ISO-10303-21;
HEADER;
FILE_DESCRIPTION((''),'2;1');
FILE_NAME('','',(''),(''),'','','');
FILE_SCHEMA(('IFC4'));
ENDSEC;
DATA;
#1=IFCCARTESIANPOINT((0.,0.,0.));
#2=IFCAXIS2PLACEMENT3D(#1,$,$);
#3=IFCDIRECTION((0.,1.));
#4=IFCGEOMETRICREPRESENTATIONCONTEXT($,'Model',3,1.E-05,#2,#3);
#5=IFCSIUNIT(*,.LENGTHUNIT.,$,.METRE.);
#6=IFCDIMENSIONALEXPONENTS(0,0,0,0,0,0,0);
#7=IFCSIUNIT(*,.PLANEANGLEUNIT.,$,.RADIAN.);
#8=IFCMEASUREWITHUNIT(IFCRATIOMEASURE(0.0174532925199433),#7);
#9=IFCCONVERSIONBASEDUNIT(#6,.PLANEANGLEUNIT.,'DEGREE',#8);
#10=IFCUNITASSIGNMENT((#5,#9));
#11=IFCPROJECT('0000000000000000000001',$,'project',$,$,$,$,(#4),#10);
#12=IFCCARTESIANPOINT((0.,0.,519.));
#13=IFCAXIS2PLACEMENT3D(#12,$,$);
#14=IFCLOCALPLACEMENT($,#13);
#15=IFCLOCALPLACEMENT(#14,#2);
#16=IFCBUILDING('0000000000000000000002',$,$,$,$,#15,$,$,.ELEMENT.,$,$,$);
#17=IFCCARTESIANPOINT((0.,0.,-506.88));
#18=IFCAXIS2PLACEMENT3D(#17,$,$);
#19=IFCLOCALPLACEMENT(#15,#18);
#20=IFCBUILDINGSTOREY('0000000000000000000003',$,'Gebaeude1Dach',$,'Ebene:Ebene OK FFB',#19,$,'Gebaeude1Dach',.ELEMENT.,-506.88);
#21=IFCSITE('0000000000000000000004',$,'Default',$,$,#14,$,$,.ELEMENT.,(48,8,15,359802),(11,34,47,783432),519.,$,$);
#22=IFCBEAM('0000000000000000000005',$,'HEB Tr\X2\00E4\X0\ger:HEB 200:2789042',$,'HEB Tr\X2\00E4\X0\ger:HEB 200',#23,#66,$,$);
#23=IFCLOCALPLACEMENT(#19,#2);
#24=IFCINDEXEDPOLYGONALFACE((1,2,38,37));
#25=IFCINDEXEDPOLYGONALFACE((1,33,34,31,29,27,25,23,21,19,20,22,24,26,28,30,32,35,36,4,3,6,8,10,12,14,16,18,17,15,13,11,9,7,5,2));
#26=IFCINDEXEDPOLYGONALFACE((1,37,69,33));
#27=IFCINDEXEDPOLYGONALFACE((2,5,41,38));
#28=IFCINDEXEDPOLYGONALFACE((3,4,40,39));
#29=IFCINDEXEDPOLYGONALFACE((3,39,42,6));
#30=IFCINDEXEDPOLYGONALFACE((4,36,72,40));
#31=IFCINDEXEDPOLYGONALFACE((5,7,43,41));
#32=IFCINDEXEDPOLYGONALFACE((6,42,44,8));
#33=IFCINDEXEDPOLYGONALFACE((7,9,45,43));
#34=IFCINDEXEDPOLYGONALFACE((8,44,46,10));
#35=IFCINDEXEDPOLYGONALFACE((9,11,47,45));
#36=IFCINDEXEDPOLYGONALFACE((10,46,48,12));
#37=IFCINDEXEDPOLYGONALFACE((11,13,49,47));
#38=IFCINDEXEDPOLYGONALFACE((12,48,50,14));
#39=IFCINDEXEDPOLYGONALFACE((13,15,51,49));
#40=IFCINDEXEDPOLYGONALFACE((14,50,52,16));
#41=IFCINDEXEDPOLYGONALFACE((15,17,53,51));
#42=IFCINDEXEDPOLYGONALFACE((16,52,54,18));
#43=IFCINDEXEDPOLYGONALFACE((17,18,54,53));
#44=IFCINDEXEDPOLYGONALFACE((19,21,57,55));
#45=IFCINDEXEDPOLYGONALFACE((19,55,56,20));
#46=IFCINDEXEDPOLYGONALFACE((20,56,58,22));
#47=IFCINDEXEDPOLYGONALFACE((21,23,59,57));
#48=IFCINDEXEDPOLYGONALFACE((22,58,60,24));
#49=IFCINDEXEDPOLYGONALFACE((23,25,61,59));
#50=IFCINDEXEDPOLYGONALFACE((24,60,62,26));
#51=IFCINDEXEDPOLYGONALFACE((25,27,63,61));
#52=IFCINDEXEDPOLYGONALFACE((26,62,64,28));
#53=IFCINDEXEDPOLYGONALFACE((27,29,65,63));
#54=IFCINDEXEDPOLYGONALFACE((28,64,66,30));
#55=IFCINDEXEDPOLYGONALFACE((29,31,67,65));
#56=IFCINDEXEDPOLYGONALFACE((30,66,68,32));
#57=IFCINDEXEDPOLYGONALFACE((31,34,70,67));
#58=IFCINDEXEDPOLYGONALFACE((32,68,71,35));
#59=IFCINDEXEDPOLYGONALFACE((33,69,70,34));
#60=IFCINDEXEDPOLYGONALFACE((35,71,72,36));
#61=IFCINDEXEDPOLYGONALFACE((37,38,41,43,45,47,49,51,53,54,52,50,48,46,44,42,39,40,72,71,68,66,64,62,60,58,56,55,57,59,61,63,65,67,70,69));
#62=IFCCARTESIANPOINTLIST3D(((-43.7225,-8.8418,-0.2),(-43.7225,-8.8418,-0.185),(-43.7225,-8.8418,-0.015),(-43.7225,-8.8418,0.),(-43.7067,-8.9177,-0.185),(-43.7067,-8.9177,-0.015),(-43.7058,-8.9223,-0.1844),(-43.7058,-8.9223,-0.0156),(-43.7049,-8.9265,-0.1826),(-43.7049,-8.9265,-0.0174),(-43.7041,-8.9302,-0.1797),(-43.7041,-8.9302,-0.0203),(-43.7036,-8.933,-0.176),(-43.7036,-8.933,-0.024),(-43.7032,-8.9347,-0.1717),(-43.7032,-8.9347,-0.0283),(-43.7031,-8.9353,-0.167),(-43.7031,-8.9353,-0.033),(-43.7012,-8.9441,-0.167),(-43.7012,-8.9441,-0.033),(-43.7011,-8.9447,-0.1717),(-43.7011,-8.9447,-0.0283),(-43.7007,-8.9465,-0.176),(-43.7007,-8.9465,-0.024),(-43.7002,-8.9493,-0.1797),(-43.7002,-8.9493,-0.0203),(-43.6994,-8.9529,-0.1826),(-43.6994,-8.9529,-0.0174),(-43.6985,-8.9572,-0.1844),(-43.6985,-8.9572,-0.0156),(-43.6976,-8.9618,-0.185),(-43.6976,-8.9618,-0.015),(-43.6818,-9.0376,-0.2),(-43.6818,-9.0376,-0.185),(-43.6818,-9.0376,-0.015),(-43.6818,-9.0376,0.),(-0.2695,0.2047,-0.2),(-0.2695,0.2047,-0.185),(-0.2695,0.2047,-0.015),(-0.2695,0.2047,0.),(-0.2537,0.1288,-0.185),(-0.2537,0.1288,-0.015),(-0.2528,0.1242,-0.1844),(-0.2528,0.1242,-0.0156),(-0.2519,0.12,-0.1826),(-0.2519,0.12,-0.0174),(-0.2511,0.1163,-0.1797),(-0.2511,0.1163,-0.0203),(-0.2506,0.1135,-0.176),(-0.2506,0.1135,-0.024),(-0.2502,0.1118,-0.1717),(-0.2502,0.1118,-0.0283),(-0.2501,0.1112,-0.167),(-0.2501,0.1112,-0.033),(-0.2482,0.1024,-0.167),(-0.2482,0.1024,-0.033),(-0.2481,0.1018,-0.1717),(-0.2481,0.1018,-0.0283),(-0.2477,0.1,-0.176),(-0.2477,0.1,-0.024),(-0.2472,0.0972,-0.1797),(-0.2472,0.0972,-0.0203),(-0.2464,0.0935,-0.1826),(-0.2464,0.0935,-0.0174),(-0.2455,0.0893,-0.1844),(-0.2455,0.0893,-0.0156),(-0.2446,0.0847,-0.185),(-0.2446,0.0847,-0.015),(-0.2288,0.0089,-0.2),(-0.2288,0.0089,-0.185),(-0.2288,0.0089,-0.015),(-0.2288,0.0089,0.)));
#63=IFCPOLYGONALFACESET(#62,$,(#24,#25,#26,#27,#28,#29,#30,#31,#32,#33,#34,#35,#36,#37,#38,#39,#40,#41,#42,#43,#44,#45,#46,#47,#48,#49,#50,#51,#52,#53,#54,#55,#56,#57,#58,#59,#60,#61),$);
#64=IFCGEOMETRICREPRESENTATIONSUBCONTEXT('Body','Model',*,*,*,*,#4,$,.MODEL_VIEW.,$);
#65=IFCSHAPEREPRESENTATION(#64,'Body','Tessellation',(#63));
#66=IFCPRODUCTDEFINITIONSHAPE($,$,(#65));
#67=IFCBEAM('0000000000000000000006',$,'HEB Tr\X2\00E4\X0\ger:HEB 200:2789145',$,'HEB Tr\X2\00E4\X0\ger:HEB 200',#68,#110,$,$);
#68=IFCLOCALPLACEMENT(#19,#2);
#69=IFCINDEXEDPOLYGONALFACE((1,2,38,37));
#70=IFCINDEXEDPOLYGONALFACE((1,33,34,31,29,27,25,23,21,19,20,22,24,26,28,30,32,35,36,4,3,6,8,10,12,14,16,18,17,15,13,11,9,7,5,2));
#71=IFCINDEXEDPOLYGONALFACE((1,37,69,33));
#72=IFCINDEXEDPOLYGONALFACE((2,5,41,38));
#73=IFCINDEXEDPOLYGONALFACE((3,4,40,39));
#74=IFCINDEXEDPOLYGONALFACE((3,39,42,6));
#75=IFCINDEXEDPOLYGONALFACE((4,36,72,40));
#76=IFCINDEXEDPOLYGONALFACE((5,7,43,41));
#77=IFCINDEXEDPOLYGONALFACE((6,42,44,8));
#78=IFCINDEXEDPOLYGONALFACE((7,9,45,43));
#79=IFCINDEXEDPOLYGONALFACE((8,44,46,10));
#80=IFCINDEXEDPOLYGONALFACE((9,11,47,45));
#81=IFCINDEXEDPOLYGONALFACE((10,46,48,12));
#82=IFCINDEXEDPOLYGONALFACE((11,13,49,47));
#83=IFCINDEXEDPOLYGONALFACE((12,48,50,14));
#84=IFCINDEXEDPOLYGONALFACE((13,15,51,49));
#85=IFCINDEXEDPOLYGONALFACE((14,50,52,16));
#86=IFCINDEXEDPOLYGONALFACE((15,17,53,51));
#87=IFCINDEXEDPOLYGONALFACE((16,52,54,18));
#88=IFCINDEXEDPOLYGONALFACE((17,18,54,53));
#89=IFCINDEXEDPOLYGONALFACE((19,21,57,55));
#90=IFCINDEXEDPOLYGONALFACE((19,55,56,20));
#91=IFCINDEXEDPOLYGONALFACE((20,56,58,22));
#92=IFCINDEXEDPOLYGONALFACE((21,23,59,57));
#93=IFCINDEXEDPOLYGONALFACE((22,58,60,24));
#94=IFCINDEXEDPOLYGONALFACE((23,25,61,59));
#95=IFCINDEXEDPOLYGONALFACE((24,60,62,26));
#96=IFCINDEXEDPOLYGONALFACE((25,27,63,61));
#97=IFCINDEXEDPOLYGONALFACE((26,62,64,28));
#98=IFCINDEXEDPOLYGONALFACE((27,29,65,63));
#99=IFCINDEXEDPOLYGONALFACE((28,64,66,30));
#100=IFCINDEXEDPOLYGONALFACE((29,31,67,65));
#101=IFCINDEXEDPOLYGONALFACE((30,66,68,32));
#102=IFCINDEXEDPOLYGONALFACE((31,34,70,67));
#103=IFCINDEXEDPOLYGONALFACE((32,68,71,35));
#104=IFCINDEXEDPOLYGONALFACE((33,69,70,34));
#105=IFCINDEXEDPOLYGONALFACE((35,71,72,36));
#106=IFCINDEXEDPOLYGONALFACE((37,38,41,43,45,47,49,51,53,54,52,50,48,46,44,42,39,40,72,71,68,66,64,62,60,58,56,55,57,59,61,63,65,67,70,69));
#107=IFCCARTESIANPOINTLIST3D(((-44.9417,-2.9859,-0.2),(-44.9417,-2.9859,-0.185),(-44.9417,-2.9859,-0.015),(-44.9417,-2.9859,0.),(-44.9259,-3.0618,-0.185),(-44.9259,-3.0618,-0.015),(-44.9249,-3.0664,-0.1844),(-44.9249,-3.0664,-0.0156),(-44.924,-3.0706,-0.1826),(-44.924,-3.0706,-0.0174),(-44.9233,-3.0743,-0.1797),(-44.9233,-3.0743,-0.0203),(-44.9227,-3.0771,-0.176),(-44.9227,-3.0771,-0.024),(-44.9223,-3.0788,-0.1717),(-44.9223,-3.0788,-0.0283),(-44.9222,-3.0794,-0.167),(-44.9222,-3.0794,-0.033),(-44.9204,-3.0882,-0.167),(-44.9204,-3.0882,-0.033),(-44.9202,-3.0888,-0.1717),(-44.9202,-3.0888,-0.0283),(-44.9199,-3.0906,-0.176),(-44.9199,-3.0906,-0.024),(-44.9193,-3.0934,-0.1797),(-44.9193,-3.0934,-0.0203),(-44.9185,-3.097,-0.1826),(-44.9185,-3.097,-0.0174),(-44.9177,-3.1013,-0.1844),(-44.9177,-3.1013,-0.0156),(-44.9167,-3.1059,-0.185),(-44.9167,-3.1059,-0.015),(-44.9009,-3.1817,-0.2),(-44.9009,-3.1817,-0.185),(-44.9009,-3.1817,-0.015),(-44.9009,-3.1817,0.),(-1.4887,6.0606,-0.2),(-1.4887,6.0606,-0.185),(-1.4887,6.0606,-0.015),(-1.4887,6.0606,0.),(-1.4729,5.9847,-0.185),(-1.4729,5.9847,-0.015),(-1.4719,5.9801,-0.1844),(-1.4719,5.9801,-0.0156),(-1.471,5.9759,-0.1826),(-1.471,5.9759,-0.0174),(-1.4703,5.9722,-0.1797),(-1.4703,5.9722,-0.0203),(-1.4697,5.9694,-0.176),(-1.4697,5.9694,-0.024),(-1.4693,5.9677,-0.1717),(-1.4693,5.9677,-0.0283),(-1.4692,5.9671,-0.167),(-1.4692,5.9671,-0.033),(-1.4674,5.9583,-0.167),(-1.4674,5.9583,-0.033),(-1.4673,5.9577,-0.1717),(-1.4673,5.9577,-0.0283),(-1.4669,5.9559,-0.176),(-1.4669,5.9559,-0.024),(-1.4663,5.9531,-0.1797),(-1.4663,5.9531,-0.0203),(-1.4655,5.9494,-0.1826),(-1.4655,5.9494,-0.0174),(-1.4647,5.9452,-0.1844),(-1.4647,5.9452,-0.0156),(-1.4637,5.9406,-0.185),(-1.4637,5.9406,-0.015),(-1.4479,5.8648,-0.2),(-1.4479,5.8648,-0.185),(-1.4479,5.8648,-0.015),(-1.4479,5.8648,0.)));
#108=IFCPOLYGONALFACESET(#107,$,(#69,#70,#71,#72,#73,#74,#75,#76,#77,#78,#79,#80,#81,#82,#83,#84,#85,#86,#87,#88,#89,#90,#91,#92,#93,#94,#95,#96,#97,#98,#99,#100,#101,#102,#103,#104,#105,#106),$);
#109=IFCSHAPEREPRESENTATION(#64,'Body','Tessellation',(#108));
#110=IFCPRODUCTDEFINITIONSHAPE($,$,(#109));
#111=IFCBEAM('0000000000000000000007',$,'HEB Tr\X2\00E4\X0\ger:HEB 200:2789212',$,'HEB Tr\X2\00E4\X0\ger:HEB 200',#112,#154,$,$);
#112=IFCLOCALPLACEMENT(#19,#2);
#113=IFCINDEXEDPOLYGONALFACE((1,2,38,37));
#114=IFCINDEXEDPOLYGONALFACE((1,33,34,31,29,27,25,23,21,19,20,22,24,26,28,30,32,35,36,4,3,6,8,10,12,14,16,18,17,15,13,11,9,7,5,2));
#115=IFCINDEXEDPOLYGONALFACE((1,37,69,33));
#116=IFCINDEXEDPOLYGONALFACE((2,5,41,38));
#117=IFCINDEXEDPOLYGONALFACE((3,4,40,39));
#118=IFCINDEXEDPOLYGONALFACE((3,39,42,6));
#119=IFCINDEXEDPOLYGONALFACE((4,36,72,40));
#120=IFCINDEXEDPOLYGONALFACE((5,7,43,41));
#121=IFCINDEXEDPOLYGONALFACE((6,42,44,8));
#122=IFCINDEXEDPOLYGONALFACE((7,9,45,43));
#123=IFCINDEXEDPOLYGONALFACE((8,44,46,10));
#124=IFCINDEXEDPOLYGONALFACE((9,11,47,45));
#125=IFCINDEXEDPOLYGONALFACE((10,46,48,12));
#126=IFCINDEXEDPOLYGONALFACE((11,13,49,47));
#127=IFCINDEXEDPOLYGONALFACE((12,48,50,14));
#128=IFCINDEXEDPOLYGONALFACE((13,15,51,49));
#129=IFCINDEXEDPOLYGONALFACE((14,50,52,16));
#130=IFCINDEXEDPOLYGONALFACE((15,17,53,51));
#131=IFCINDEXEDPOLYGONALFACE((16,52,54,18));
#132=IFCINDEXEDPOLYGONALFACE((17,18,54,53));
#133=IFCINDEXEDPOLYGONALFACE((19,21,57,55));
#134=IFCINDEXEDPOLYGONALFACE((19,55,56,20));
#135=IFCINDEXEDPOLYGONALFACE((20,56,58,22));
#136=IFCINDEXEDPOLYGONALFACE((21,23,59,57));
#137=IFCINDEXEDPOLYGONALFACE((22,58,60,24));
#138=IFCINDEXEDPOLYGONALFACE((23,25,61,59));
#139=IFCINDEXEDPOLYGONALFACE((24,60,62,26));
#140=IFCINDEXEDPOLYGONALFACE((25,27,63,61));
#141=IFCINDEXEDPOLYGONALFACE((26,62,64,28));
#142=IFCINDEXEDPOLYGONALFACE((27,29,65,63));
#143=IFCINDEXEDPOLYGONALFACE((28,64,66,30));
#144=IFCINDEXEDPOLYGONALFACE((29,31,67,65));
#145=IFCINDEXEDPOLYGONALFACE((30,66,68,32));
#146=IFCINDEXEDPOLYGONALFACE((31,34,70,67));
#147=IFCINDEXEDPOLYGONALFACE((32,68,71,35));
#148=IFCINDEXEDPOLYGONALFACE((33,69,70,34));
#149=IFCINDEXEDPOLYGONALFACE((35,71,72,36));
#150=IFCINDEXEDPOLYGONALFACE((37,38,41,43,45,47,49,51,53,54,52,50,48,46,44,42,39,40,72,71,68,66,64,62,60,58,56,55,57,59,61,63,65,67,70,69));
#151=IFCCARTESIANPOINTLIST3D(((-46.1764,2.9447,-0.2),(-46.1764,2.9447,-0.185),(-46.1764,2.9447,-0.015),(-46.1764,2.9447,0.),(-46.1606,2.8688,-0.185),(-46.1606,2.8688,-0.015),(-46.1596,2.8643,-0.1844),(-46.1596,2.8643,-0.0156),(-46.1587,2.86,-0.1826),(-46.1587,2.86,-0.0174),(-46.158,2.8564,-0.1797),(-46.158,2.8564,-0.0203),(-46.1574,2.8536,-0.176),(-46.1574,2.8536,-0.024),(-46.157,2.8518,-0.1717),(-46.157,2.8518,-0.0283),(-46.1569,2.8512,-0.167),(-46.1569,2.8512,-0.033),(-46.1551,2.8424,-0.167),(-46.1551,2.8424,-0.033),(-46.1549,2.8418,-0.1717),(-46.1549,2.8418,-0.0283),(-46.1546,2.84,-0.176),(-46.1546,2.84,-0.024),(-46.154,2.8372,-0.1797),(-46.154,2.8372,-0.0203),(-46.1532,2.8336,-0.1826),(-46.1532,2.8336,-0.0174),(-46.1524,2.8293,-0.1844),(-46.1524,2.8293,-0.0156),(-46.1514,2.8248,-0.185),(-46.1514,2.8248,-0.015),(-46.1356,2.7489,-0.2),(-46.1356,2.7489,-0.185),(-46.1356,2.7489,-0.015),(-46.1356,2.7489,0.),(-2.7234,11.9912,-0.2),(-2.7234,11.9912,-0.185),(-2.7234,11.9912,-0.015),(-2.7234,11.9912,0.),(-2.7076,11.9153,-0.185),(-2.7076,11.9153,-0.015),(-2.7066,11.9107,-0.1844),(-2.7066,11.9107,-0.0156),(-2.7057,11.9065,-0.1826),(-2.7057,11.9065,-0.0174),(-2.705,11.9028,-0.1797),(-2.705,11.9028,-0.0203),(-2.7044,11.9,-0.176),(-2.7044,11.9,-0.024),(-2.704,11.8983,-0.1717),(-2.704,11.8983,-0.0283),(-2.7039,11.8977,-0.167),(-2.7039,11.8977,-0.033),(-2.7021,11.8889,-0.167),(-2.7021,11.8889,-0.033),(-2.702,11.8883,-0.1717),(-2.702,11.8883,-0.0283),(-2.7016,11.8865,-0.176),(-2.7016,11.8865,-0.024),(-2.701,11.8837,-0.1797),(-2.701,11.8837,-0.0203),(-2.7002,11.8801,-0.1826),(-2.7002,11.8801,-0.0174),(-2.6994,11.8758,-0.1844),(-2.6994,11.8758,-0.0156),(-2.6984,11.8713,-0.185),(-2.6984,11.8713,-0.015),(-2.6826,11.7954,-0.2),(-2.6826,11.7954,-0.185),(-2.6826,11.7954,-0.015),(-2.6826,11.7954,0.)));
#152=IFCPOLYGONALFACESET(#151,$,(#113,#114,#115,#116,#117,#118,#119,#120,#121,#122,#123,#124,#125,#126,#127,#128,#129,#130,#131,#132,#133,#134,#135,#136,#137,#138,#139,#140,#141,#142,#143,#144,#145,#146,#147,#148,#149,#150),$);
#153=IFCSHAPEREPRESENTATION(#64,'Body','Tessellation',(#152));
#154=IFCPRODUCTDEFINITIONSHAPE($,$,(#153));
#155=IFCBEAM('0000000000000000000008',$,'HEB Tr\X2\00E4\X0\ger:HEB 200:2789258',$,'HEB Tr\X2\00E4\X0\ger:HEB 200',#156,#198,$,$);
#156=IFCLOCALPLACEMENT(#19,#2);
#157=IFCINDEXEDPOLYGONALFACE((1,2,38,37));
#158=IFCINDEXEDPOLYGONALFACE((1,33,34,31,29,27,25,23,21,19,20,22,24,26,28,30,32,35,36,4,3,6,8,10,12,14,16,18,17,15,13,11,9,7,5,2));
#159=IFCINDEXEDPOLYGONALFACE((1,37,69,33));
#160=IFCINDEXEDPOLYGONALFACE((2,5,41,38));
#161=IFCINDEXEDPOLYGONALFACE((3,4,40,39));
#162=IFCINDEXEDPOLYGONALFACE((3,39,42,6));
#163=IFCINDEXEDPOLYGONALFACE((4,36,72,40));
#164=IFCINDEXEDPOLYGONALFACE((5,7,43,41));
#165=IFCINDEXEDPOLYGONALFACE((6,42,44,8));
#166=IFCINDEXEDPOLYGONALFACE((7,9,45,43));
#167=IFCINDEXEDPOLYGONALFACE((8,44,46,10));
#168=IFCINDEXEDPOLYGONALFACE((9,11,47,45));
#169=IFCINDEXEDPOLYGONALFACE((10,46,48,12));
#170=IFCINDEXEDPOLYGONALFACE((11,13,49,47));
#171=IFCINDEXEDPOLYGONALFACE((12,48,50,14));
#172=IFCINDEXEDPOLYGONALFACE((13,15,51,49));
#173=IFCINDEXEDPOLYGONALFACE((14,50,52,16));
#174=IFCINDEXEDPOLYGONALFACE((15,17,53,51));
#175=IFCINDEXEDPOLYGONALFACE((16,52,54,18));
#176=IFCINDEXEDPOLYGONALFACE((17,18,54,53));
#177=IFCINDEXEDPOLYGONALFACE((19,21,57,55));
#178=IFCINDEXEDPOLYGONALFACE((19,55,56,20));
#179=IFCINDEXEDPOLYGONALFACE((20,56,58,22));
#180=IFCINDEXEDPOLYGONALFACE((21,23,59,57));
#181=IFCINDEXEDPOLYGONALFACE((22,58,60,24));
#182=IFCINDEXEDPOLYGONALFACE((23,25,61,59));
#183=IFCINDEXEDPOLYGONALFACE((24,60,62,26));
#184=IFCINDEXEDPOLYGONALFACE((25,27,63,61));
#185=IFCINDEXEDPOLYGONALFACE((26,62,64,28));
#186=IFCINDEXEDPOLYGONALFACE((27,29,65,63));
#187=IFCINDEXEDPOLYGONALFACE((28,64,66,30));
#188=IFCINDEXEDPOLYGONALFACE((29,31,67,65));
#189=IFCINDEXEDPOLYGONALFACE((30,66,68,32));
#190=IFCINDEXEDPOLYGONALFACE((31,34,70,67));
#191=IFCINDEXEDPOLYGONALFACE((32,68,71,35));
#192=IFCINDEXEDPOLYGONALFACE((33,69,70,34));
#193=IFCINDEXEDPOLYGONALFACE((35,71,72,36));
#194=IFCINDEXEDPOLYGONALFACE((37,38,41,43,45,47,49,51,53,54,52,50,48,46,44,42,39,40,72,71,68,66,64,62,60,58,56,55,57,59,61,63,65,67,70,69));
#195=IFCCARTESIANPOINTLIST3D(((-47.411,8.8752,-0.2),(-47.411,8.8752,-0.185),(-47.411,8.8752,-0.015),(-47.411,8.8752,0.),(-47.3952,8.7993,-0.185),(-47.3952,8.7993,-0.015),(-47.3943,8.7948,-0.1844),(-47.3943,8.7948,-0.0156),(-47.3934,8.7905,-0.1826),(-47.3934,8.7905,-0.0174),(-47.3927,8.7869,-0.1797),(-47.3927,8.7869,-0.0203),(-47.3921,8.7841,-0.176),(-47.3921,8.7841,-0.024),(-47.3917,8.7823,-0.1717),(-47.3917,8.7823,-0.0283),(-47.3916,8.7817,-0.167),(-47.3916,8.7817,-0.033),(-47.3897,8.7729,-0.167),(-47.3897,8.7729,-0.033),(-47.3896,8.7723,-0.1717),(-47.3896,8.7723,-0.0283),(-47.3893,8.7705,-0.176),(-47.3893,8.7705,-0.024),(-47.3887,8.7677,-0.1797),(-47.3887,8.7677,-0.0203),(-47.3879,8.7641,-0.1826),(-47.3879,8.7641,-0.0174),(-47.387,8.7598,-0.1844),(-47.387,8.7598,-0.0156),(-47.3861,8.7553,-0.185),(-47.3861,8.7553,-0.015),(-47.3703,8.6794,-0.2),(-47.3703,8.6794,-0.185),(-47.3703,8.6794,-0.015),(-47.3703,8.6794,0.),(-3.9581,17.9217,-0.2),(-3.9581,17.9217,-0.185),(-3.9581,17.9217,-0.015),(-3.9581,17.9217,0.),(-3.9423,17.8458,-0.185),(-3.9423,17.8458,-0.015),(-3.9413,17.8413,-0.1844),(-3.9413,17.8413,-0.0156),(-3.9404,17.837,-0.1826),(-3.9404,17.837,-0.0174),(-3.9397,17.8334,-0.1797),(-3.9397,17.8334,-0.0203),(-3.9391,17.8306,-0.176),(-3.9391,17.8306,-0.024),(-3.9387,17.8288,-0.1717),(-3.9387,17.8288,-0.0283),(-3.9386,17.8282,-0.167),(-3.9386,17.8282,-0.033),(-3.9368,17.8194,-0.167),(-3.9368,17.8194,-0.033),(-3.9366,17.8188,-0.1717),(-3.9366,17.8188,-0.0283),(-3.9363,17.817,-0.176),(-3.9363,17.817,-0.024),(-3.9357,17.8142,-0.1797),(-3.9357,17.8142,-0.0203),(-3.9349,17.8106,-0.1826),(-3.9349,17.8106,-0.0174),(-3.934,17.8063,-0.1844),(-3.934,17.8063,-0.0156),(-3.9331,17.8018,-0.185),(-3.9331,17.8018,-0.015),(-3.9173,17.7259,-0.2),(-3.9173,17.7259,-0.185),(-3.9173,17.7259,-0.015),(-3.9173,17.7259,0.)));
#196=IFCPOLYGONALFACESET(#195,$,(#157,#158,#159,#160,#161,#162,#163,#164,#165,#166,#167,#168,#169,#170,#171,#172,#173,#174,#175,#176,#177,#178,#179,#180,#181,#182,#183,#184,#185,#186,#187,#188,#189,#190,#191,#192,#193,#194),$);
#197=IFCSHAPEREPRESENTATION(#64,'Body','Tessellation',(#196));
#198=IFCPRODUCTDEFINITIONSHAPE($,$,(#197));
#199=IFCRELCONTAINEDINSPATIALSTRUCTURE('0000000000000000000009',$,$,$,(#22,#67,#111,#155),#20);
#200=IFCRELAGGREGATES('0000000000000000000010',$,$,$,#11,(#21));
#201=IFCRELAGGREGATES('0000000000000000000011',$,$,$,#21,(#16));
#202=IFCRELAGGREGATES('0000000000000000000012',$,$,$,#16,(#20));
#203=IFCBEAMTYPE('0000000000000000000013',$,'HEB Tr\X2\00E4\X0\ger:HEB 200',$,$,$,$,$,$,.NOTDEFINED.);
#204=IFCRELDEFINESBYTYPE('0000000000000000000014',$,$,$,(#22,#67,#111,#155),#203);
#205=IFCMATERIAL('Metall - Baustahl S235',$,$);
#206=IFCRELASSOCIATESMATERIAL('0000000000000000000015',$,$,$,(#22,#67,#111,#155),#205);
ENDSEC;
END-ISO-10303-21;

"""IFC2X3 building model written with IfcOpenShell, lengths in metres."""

from ifc_helpers import new_model, entity, si_unit, converted_unit, direction, frame, frame_2d, origin, place, context, subcontext, project, spatial, i_section, extrude, material, type_object, element, save


model = new_model("IFC2X3")

# Units and contexts
model_context = context("Model", 3, precision=1e-05, world=origin(), true_north=direction((0.0, 1.0)))
body_context = subcontext(model_context, "Body", "Model", "MODEL_VIEW")
ifc_project = project(units=[si_unit("LENGTHUNIT", "METRE"), converted_unit("PLANEANGLEUNIT", "DEGREE", entity("IfcRatioMeasure", 0.0174532925199433), si_unit("PLANEANGLEUNIT", "RADIAN"), dimensions=[0, 0, 0, 0, 0, 0, 0])], contexts=[model_context])

# Site, building, storey
site_placement = place(None, frame((0.0, 0.0, 519.0)))
site = spatial("IfcSite", under=ifc_project, at=site_placement, Name="Default", CompositionType="ELEMENT", RefLatitude=(48, 8, 15, 359802), RefLongitude=(11, 34, 47, 783432), RefElevation=519.0)
building_placement = place(site_placement, origin())
building = spatial("IfcBuilding", under=site, at=building_placement, CompositionType="ELEMENT")
storey_placement = place(building_placement, frame((0.0, 0.0, -506.88)))
storey = spatial("IfcBuildingStorey", under=building, at=storey_placement, Name="Gebaeude1Dach", ObjectType="Ebene:Ebene OK FFB", LongName="Gebaeude1Dach", CompositionType="ELEMENT", Elevation=-506.88)

# Beams
ifc_material = material(Name="Metall - Baustahl S235")
beam_type = type_object("IfcBeamType", Name="HEB Träger:HEB 200", PredefinedType="NOTDEFINED")
beam_1_placement = place(storey_placement, frame((-0.1358, 0.1304, 0.0), z_axis=(0.0, 0.0, 1.0), x_axis=(-0.979008, -0.20382, 0.0)))
element("IfcBeam", 1, at=beam_1_placement, inside=storey, type_object=beam_type, material=ifc_material, Name="HEB Träger:HEB 200:2789042", ObjectType="HEB Träger:HEB 200", context=body_context, shape_type="SweptSolid", body=[
    extrude(i_section(OverallWidth=0.2, OverallDepth=0.2, WebThickness=0.009, FlangeThickness=0.015, FilletRadius=0.018, at=frame_2d((0.0, 0.0), x_axis=(0.0, 1.0))), frame((0.1157, 0.0, -0.1), z_axis=(1.0, 0.0, 0.0), x_axis=(0.0, 0.0, -1.0)), (0.0, 0.0, 1.0), 44.3847),
])
beam_2_placement = place(storey_placement, frame((-1.355, 5.9862, 0.0), z_axis=(0.0, 0.0, 1.0), x_axis=(-0.979008, -0.20382, 0.0)))
element("IfcBeam", 2, at=beam_2_placement, inside=storey, type_object=beam_type, material=ifc_material, Name="HEB Träger:HEB 200:2789145", ObjectType="HEB Träger:HEB 200", context=body_context, shape_type="SweptSolid", body=[
    extrude(i_section(OverallWidth=0.2, OverallDepth=0.2, WebThickness=0.009, FlangeThickness=0.015, FilletRadius=0.018, at=frame_2d((0.0, 0.0), x_axis=(0.0, 1.0))), frame((0.1157, 0.0, -0.1), z_axis=(1.0, 0.0, 0.0), x_axis=(0.0, 0.0, -1.0)), (0.0, 0.0, 1.0), 44.3847),
])
beam_3_placement = place(storey_placement, frame((-2.5897, 11.9169, 0.0), z_axis=(0.0, 0.0, 1.0), x_axis=(-0.979008, -0.20382, 0.0)))
element("IfcBeam", 3, at=beam_3_placement, inside=storey, type_object=beam_type, material=ifc_material, Name="HEB Träger:HEB 200:2789212", ObjectType="HEB Träger:HEB 200", context=body_context, shape_type="SweptSolid", body=[
    extrude(i_section(OverallWidth=0.2, OverallDepth=0.2, WebThickness=0.009, FlangeThickness=0.015, FilletRadius=0.018, at=frame_2d((0.0, 0.0), x_axis=(0.0, 1.0))), frame((0.1157, 0.0, -0.1), z_axis=(1.0, 0.0, 0.0), x_axis=(0.0, 0.0, -1.0)), (0.0, 0.0, 1.0), 44.3847),
])
beam_4_placement = place(storey_placement, frame((-3.8244, 17.8474, 0.0), z_axis=(0.0, 0.0, 1.0), x_axis=(-0.979008, -0.20382, 0.0)))
element("IfcBeam", 4, at=beam_4_placement, inside=storey, type_object=beam_type, material=ifc_material, Name="HEB Träger:HEB 200:2789258", ObjectType="HEB Träger:HEB 200", context=body_context, shape_type="SweptSolid", body=[
    extrude(i_section(OverallWidth=0.2, OverallDepth=0.2, WebThickness=0.009, FlangeThickness=0.015, FilletRadius=0.018, at=frame_2d((0.0, 0.0), x_axis=(0.0, 1.0))), frame((0.1157, 0.0, -0.1), z_axis=(1.0, 0.0, 0.0), x_axis=(0.0, 0.0, -1.0)), (0.0, 0.0, 1.0), 44.3847),
])

save(model, "model.ifc")
